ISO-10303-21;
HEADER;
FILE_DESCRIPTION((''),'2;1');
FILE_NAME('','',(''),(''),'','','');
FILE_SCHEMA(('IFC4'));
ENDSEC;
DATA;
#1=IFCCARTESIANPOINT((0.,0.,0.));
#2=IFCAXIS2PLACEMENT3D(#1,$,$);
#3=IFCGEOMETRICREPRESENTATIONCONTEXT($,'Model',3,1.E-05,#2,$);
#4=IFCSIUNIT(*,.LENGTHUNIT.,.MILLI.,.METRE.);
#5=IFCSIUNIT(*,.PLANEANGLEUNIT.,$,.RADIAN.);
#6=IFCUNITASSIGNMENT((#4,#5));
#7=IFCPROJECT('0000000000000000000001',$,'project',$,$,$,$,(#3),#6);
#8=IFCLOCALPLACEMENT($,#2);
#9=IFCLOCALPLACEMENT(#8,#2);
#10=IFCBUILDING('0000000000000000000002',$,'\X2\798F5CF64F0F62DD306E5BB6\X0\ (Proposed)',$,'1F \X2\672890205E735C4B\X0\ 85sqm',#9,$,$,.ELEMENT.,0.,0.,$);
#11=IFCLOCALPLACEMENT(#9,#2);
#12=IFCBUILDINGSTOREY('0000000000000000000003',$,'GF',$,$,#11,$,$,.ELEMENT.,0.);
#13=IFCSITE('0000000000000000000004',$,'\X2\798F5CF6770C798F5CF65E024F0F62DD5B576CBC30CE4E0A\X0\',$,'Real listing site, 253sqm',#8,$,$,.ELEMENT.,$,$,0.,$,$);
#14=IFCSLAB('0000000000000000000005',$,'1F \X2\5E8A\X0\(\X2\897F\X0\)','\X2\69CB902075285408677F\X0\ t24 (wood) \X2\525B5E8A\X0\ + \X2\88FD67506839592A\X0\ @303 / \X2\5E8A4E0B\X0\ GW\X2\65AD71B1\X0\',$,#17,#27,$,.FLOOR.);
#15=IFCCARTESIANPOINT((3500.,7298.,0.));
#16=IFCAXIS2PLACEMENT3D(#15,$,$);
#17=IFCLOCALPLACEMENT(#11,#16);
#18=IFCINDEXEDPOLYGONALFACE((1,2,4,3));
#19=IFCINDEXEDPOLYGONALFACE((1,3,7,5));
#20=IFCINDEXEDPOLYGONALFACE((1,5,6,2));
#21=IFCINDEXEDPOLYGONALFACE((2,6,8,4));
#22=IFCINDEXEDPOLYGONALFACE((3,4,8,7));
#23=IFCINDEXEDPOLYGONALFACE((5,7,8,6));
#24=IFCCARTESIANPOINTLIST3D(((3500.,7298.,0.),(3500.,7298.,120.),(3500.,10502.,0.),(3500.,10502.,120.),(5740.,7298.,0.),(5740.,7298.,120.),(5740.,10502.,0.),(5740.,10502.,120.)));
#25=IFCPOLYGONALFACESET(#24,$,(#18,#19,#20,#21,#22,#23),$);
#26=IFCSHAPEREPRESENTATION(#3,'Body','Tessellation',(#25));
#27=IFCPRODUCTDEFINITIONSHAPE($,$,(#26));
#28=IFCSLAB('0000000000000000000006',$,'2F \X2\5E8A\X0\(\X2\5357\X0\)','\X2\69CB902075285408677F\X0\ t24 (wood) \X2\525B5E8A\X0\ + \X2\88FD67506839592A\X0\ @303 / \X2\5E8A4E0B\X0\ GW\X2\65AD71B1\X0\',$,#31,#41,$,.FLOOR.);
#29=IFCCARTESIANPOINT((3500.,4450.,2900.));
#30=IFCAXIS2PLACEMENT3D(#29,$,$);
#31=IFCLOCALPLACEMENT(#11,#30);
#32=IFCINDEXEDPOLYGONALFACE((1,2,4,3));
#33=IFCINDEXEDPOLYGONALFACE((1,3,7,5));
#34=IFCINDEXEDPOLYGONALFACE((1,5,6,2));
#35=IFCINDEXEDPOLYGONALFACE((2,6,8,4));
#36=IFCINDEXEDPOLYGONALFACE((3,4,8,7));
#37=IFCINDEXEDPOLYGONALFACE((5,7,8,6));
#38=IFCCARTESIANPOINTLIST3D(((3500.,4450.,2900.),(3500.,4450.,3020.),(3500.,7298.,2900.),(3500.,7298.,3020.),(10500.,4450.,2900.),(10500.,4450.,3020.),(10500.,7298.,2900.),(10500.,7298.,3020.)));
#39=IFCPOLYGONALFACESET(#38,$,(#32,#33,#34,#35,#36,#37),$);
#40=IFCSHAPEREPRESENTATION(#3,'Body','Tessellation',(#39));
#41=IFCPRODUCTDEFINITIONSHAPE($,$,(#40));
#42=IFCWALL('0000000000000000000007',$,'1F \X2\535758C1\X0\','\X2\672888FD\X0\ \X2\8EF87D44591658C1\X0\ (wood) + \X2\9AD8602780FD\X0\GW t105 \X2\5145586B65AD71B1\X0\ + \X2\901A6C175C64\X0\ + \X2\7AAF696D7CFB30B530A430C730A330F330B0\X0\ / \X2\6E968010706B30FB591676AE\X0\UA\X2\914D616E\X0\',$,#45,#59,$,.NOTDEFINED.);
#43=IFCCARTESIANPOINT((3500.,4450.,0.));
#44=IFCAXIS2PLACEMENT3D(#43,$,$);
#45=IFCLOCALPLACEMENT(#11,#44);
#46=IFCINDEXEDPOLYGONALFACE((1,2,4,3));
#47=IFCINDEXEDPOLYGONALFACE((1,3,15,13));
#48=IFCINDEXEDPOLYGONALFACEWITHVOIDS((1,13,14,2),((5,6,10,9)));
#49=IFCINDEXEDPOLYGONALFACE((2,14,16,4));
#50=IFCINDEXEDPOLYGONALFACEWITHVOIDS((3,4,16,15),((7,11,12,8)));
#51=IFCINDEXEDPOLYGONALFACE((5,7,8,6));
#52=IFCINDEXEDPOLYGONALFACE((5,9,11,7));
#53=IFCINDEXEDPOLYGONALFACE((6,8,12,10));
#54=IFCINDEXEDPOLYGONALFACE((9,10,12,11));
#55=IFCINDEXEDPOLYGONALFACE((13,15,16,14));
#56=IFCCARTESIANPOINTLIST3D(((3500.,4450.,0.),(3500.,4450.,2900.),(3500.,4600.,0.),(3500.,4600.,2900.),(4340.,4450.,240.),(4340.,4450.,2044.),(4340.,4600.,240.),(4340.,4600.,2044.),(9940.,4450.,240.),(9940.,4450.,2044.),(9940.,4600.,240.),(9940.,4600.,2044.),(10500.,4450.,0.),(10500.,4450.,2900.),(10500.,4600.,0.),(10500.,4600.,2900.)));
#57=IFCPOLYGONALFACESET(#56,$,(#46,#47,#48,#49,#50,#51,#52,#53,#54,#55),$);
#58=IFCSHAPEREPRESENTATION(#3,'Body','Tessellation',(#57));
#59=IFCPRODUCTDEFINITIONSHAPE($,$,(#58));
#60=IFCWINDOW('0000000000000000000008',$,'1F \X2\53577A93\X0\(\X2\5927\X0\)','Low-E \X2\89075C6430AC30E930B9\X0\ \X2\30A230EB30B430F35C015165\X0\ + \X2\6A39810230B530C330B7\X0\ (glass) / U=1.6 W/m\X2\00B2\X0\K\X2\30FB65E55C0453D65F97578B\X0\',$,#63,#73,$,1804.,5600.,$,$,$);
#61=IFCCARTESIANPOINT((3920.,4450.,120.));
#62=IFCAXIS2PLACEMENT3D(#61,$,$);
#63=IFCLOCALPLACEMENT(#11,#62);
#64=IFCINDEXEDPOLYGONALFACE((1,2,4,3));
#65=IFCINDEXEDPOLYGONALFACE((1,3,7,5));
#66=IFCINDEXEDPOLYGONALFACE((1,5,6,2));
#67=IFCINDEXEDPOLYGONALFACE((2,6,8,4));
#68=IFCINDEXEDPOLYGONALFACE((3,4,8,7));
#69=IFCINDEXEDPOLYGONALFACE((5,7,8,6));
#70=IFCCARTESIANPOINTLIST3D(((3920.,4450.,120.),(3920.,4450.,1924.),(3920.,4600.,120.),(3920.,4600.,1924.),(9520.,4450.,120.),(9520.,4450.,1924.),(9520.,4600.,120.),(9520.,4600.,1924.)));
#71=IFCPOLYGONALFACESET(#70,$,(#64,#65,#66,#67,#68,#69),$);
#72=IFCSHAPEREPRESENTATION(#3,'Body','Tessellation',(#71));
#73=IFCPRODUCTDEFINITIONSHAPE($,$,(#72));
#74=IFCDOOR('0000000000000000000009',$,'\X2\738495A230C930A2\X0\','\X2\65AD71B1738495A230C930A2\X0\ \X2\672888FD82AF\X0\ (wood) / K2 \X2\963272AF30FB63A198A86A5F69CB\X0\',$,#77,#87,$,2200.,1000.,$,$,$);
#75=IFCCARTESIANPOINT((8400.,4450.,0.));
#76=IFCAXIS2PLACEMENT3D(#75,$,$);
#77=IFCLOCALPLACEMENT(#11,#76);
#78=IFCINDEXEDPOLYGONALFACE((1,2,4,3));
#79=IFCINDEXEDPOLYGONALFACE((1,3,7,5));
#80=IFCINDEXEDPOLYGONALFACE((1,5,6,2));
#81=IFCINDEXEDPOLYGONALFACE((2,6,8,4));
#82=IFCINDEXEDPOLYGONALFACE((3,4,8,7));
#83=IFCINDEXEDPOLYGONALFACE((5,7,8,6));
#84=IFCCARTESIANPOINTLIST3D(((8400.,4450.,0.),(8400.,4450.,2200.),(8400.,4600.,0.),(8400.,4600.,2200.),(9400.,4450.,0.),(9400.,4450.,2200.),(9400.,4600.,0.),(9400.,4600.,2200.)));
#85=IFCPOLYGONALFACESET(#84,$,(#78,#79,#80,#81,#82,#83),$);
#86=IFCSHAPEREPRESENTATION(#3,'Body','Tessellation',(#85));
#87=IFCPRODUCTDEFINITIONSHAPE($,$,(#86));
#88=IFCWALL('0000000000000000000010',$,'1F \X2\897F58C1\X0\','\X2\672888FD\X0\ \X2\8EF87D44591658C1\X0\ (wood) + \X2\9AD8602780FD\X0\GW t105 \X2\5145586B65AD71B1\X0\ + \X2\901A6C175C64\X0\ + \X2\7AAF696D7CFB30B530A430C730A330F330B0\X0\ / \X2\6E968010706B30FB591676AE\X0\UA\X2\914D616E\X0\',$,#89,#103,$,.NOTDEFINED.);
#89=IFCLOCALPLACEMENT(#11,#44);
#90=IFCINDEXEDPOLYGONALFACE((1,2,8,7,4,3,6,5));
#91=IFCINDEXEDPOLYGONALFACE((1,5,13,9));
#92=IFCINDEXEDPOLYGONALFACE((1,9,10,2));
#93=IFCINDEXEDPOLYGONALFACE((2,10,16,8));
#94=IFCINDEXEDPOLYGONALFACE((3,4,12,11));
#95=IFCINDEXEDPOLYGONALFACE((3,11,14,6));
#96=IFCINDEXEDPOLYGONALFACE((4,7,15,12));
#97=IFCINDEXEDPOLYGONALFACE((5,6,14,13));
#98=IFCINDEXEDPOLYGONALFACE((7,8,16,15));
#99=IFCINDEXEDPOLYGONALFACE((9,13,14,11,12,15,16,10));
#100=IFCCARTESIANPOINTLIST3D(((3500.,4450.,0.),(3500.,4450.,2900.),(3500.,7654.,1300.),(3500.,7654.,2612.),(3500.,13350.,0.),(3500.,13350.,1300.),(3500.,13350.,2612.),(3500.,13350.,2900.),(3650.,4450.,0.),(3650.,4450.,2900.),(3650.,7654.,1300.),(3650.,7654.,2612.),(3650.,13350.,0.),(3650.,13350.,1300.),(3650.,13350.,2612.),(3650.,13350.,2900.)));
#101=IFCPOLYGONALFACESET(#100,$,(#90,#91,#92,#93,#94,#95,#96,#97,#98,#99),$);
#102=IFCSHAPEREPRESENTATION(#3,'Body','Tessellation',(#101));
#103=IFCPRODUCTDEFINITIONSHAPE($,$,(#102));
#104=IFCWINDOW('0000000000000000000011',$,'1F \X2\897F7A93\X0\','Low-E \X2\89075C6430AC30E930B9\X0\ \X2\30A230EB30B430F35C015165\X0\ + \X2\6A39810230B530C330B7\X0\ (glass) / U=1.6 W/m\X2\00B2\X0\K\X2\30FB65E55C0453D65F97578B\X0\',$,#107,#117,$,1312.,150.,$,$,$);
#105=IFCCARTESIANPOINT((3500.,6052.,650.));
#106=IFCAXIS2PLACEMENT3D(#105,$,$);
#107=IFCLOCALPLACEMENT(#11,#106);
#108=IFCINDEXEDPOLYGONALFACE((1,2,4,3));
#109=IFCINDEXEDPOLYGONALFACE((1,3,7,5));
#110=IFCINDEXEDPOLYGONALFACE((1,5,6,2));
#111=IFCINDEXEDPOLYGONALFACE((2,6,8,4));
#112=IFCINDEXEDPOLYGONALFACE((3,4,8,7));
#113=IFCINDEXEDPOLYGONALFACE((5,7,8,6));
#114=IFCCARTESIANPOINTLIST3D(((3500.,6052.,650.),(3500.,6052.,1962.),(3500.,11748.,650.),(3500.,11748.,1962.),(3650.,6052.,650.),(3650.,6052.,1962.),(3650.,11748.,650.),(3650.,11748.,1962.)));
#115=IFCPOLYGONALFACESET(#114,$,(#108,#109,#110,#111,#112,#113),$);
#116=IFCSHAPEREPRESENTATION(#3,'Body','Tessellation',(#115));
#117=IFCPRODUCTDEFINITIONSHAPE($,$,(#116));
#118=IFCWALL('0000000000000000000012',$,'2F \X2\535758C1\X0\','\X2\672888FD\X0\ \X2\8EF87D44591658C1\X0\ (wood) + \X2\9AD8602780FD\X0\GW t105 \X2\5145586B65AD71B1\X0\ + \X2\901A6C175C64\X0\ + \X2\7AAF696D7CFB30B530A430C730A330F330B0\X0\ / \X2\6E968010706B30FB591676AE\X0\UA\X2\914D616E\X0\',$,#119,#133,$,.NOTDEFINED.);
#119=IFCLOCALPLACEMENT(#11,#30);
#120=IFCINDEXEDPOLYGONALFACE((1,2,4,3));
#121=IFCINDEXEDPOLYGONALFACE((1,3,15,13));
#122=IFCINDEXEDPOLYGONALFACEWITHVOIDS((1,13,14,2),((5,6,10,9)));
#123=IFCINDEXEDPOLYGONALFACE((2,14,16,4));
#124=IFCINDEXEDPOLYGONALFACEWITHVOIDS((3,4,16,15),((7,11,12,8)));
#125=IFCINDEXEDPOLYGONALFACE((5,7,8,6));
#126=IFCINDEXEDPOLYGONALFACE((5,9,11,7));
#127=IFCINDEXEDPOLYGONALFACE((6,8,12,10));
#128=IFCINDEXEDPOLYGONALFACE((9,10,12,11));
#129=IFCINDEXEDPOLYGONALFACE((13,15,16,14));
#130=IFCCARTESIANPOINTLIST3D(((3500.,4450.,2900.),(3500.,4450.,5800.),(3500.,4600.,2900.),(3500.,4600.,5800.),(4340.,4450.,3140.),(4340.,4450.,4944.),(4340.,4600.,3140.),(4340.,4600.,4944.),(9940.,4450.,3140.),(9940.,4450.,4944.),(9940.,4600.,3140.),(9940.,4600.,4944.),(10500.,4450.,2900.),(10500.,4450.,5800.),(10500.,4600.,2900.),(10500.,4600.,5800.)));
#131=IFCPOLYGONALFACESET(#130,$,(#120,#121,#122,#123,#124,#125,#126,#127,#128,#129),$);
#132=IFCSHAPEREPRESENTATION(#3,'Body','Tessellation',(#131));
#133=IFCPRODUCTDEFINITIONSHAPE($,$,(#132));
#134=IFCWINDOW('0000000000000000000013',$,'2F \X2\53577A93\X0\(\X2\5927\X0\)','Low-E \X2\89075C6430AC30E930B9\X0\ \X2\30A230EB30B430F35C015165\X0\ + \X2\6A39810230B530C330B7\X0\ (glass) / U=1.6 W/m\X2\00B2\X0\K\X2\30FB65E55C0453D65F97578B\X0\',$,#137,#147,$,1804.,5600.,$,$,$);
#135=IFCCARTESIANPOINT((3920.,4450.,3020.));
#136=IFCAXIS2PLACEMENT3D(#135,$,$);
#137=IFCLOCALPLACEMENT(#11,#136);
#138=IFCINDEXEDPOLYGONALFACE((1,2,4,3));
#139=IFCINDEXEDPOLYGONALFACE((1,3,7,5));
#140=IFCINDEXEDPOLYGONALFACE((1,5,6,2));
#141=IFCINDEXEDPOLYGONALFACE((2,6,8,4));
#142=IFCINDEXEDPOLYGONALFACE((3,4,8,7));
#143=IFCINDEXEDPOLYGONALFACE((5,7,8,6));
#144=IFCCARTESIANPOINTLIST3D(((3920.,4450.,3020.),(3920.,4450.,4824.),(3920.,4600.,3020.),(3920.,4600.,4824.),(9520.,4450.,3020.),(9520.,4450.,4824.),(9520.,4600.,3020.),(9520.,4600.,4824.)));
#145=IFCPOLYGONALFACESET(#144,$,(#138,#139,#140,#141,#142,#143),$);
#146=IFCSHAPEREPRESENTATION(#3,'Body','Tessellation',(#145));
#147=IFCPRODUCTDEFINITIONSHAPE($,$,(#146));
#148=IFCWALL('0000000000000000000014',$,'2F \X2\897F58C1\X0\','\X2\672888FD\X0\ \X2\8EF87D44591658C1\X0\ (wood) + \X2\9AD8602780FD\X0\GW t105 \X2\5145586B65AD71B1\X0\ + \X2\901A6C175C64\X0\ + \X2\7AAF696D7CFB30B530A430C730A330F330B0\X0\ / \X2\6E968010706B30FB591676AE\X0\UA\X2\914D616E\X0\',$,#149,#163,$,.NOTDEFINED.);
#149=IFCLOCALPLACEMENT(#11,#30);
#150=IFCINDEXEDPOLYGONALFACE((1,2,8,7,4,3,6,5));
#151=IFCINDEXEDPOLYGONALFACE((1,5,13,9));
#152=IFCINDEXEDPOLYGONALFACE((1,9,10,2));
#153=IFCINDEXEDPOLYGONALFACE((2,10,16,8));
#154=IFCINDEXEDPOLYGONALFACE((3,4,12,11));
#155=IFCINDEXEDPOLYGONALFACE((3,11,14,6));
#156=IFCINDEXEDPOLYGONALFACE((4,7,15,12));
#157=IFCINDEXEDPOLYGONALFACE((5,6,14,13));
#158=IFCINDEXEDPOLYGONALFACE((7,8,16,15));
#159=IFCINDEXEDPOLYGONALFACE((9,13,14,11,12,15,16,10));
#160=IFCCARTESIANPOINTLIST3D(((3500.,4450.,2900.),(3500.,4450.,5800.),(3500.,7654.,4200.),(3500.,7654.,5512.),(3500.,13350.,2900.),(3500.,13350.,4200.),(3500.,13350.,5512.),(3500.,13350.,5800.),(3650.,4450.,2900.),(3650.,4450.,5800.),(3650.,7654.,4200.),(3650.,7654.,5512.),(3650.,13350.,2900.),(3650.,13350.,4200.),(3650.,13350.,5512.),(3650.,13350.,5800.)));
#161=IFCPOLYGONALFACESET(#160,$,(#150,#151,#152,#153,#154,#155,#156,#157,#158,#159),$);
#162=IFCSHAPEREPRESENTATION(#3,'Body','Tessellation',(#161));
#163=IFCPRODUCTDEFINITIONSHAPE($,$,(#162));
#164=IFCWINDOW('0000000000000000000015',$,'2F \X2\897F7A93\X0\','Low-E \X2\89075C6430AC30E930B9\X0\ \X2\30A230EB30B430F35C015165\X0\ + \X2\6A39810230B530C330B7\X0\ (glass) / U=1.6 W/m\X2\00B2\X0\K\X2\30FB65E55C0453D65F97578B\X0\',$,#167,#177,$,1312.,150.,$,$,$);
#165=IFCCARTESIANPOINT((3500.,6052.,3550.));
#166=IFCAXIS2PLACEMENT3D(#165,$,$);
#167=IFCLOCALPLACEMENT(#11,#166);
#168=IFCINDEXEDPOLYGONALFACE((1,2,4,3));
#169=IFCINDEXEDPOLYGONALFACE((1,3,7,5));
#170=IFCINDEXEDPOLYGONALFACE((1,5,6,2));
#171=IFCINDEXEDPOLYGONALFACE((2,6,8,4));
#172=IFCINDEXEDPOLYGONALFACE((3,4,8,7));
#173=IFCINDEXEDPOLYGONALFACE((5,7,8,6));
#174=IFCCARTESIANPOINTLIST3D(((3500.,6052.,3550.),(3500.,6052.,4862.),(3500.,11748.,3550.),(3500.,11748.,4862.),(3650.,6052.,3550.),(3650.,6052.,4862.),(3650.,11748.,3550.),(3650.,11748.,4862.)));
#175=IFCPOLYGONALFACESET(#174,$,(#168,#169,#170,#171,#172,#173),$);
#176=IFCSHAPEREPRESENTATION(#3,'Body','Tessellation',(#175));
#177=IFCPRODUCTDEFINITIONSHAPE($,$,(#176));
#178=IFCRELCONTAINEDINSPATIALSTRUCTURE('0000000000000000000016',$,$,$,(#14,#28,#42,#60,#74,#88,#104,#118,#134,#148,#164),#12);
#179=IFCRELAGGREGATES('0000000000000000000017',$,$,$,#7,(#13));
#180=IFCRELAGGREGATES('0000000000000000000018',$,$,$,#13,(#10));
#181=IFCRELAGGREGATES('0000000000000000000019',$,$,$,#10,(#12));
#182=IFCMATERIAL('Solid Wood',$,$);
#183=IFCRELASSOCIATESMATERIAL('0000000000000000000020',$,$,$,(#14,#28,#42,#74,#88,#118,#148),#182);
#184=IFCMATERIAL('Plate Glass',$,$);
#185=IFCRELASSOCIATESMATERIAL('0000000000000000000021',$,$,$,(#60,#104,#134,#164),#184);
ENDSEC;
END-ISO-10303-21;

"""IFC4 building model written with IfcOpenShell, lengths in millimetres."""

from ifc_helpers import new_model, si_unit, frame, frame_2d, origin, place, context, project, spatial, rectangle, extrude, material, element, fill, save


model = new_model("IFC4")

# Units and contexts
model_context = context("Model", 3, precision=1e-05, world=origin())
ifc_project = project(units=[si_unit("LENGTHUNIT", "METRE", prefix="MILLI"), si_unit("PLANEANGLEUNIT", "RADIAN")], contexts=[model_context])

# Site, building, storey
site_placement = place(None, origin())
site = spatial("IfcSite", under=ifc_project, at=site_placement, Name="福島県福島市伏拝字沼ノ上", ObjectType="Real listing site, 253sqm", CompositionType="ELEMENT", RefElevation=0.0)
building_placement = place(site_placement, origin())
building = spatial("IfcBuilding", under=site, at=building_placement, Name="福島伏拝の家 (Proposed)", ObjectType="1F 木造平屋 85sqm", CompositionType="ELEMENT", ElevationOfRefHeight=0.0, ElevationOfTerrain=0.0)
storey_placement = place(building_placement, origin())
storey = spatial("IfcBuildingStorey", under=building, at=storey_placement, Name="GF", CompositionType="ELEMENT", Elevation=0.0)

# Slabs
ifc_material_1 = material(Name="Solid Wood")
slab_1_placement = place(storey_placement, frame((3500.0, 7298.0, 0.0)))
element("IfcSlab", 1, at=slab_1_placement, inside=storey, material=ifc_material_1, Name="1F 床(西)", Description="構造用合板 t24 (wood) 剛床 + 製材根太 @303 / 床下 GW断熱", PredefinedType="FLOOR", context=model_context, shape_type="SweptSolid", body=[
    extrude(rectangle(XDim=2240.0, YDim=3204.0, at=frame_2d((1120.0, 1602.0))), frame((3500.0, 7298.0, 0.0)), (0.0, 0.0, 1.0), 120.0),
])
slab_2_placement = place(storey_placement, frame((3500.0, 4450.0, 2900.0)))
element("IfcSlab", 2, at=slab_2_placement, inside=storey, material=ifc_material_1, Name="2F 床(南)", Description="構造用合板 t24 (wood) 剛床 + 製材根太 @303 / 床下 GW断熱", PredefinedType="FLOOR", context=model_context, shape_type="SweptSolid", body=[
    extrude(rectangle(XDim=7000.0, YDim=2848.0, at=frame_2d((3500.0, 1424.0))), frame((3500.0, 4450.0, 2900.0)), (0.0, 0.0, 1.0), 120.0),
])

# Wall, openings, window, door
wall_1_placement = place(storey_placement, frame((3500.0, 4450.0, 0.0)))
wall_1 = element("IfcWall", 3, at=wall_1_placement, inside=storey, material=ifc_material_1, Name="1F 南壁", Description="木製 軸組外壁 (wood) + 高性能GW t105 充填断熱 + 通気層 + 窯業系サイディング / 準耐火・外皮UA配慮", PredefinedType="NOTDEFINED", context=model_context, shape_type="SweptSolid", body=[
    extrude(rectangle(XDim=7000.0, YDim=150.0, at=frame_2d((3500.0, 75.0))), frame((3500.0, 4450.0, 0.0)), (0.0, 0.0, 1.0), 2900.0),
])
opening_1_placement = place(storey_placement, frame((3920.0, 4450.0, 120.0)))
opening_1 = element("IfcOpeningElement", 4, at=opening_1_placement, cuts=wall_1, PredefinedType="NOTDEFINED", context=model_context, shape_type="SweptSolid", body=[
    extrude(rectangle(XDim=5600.0, YDim=150.0, at=frame_2d((2800.0, 75.0))), frame((3920.0, 4450.0, 120.0)), (0.0, 0.0, 1.0), 1804.0),
])
opening_2_placement = place(storey_placement, frame((8400.0, 4450.0, 0.0)))
opening_2 = element("IfcOpeningElement", 5, at=opening_2_placement, cuts=wall_1, PredefinedType="NOTDEFINED", context=model_context, shape_type="SweptSolid", body=[
    extrude(rectangle(XDim=1000.0, YDim=150.0, at=frame_2d((500.0, 75.0))), frame((8400.0, 4450.0, 0.0)), (0.0, 0.0, 1.0), 2200.0),
])
ifc_material_2 = material(Name="Plate Glass")
window_1_placement = place(storey_placement, frame((3920.0, 4450.0, 120.0)))
window_1 = element("IfcWindow", 6, at=window_1_placement, inside=storey, material=ifc_material_2, Name="1F 南窓(大)", Description="Low-E 複層ガラス アルゴン封入 + 樹脂サッシ (glass) / U=1.6 W/m²K・日射取得型", OverallHeight=1804.0, OverallWidth=5600.0, context=model_context, shape_type="SweptSolid", body=[
    extrude(rectangle(XDim=5600.0, YDim=150.0, at=frame_2d((2800.0, 75.0))), frame((3920.0, 4450.0, 120.0)), (0.0, 0.0, 1.0), 1804.0),
])
fill(opening_1, window_1)
door_placement = place(storey_placement, frame((8400.0, 4450.0, 0.0)))
door = element("IfcDoor", 7, at=door_placement, inside=storey, material=ifc_material_1, Name="玄関ドア", Description="断熱玄関ドア 木製芯 (wood) / K2 防犯・採風機構", OverallHeight=2200.0, OverallWidth=1000.0, context=model_context, shape_type="SweptSolid", body=[
    extrude(rectangle(XDim=1000.0, YDim=150.0, at=frame_2d((500.0, 75.0))), frame((8400.0, 4450.0, 0.0)), (0.0, 0.0, 1.0), 2200.0),
])
fill(opening_2, door)

# Walls, openings, windows
wall_2_placement = place(storey_placement, frame((3500.0, 4450.0, 0.0)))
wall_2 = element("IfcWall", 8, at=wall_2_placement, inside=storey, material=ifc_material_1, Name="1F 西壁", Description="木製 軸組外壁 (wood) + 高性能GW t105 充填断熱 + 通気層 + 窯業系サイディング / 準耐火・外皮UA配慮", PredefinedType="NOTDEFINED", context=model_context, shape_type="SweptSolid", body=[
    extrude(rectangle(XDim=150.0, YDim=8900.0, at=frame_2d((75.0, 4450.0))), frame((3500.0, 4450.0, 0.0)), (0.0, 0.0, 1.0), 2900.0),
])
opening_3_placement = place(storey_placement, frame((3500.0, 6052.0, 650.0)))
opening_3 = element("IfcOpeningElement", 9, at=opening_3_placement, cuts=wall_2, PredefinedType="NOTDEFINED", context=model_context, shape_type="SweptSolid", body=[
    extrude(rectangle(XDim=150.0, YDim=5696.0, at=frame_2d((75.0, 2848.0))), frame((3500.0, 6052.0, 650.0)), (0.0, 0.0, 1.0), 1312.0),
])
window_2_placement = place(storey_placement, frame((3500.0, 6052.0, 650.0)))
window_2 = element("IfcWindow", 10, at=window_2_placement, inside=storey, material=ifc_material_2, Name="1F 西窓", Description="Low-E 複層ガラス アルゴン封入 + 樹脂サッシ (glass) / U=1.6 W/m²K・日射取得型", OverallHeight=1312.0, OverallWidth=150.0, context=model_context, shape_type="SweptSolid", body=[
    extrude(rectangle(XDim=150.0, YDim=5696.0, at=frame_2d((75.0, 2848.0))), frame((3500.0, 6052.0, 650.0)), (0.0, 0.0, 1.0), 1312.0),
])
fill(opening_3, window_2)
wall_3_placement = place(storey_placement, frame((3500.0, 4450.0, 2900.0)))
wall_3 = element("IfcWall", 11, at=wall_3_placement, inside=storey, material=ifc_material_1, Name="2F 南壁", Description="木製 軸組外壁 (wood) + 高性能GW t105 充填断熱 + 通気層 + 窯業系サイディング / 準耐火・外皮UA配慮", PredefinedType="NOTDEFINED", context=model_context, shape_type="SweptSolid", body=[
    extrude(rectangle(XDim=7000.0, YDim=150.0, at=frame_2d((3500.0, 75.0))), frame((3500.0, 4450.0, 2900.0)), (0.0, 0.0, 1.0), 2900.0),
])
opening_4_placement = place(storey_placement, frame((3920.0, 4450.0, 3020.0)))
opening_4 = element("IfcOpeningElement", 12, at=opening_4_placement, cuts=wall_3, PredefinedType="NOTDEFINED", context=model_context, shape_type="SweptSolid", body=[
    extrude(rectangle(XDim=5600.0, YDim=150.0, at=frame_2d((2800.0, 75.0))), frame((3920.0, 4450.0, 3020.0)), (0.0, 0.0, 1.0), 1804.0),
])
window_3_placement = place(storey_placement, frame((3920.0, 4450.0, 3020.0)))
window_3 = element("IfcWindow", 13, at=window_3_placement, inside=storey, material=ifc_material_2, Name="2F 南窓(大)", Description="Low-E 複層ガラス アルゴン封入 + 樹脂サッシ (glass) / U=1.6 W/m²K・日射取得型", OverallHeight=1804.0, OverallWidth=5600.0, context=model_context, shape_type="SweptSolid", body=[
    extrude(rectangle(XDim=5600.0, YDim=150.0, at=frame_2d((2800.0, 75.0))), frame((3920.0, 4450.0, 3020.0)), (0.0, 0.0, 1.0), 1804.0),
])
fill(opening_4, window_3)
wall_4_placement = place(storey_placement, frame((3500.0, 4450.0, 2900.0)))
wall_4 = element("IfcWall", 14, at=wall_4_placement, inside=storey, material=ifc_material_1, Name="2F 西壁", Description="木製 軸組外壁 (wood) + 高性能GW t105 充填断熱 + 通気層 + 窯業系サイディング / 準耐火・外皮UA配慮", PredefinedType="NOTDEFINED", context=model_context, shape_type="SweptSolid", body=[
    extrude(rectangle(XDim=150.0, YDim=8900.0, at=frame_2d((75.0, 4450.0))), frame((3500.0, 4450.0, 2900.0)), (0.0, 0.0, 1.0), 2900.0),
])
opening_5_placement = place(storey_placement, frame((3500.0, 6052.0, 3550.0)))
opening_5 = element("IfcOpeningElement", 15, at=opening_5_placement, cuts=wall_4, PredefinedType="NOTDEFINED", context=model_context, shape_type="SweptSolid", body=[
    extrude(rectangle(XDim=150.0, YDim=5696.0, at=frame_2d((75.0, 2848.0))), frame((3500.0, 6052.0, 3550.0)), (0.0, 0.0, 1.0), 1312.0),
])
window_4_placement = place(storey_placement, frame((3500.0, 6052.0, 3550.0)))
window_4 = element("IfcWindow", 16, at=window_4_placement, inside=storey, material=ifc_material_2, Name="2F 西窓", Description="Low-E 複層ガラス アルゴン封入 + 樹脂サッシ (glass) / U=1.6 W/m²K・日射取得型", OverallHeight=1312.0, OverallWidth=150.0, context=model_context, shape_type="SweptSolid", body=[
    extrude(rectangle(XDim=150.0, YDim=5696.0, at=frame_2d((75.0, 2848.0))), frame((3500.0, 6052.0, 3550.0)), (0.0, 0.0, 1.0), 1312.0),
])
fill(opening_5, window_4)

save(model, "model.ifc")
